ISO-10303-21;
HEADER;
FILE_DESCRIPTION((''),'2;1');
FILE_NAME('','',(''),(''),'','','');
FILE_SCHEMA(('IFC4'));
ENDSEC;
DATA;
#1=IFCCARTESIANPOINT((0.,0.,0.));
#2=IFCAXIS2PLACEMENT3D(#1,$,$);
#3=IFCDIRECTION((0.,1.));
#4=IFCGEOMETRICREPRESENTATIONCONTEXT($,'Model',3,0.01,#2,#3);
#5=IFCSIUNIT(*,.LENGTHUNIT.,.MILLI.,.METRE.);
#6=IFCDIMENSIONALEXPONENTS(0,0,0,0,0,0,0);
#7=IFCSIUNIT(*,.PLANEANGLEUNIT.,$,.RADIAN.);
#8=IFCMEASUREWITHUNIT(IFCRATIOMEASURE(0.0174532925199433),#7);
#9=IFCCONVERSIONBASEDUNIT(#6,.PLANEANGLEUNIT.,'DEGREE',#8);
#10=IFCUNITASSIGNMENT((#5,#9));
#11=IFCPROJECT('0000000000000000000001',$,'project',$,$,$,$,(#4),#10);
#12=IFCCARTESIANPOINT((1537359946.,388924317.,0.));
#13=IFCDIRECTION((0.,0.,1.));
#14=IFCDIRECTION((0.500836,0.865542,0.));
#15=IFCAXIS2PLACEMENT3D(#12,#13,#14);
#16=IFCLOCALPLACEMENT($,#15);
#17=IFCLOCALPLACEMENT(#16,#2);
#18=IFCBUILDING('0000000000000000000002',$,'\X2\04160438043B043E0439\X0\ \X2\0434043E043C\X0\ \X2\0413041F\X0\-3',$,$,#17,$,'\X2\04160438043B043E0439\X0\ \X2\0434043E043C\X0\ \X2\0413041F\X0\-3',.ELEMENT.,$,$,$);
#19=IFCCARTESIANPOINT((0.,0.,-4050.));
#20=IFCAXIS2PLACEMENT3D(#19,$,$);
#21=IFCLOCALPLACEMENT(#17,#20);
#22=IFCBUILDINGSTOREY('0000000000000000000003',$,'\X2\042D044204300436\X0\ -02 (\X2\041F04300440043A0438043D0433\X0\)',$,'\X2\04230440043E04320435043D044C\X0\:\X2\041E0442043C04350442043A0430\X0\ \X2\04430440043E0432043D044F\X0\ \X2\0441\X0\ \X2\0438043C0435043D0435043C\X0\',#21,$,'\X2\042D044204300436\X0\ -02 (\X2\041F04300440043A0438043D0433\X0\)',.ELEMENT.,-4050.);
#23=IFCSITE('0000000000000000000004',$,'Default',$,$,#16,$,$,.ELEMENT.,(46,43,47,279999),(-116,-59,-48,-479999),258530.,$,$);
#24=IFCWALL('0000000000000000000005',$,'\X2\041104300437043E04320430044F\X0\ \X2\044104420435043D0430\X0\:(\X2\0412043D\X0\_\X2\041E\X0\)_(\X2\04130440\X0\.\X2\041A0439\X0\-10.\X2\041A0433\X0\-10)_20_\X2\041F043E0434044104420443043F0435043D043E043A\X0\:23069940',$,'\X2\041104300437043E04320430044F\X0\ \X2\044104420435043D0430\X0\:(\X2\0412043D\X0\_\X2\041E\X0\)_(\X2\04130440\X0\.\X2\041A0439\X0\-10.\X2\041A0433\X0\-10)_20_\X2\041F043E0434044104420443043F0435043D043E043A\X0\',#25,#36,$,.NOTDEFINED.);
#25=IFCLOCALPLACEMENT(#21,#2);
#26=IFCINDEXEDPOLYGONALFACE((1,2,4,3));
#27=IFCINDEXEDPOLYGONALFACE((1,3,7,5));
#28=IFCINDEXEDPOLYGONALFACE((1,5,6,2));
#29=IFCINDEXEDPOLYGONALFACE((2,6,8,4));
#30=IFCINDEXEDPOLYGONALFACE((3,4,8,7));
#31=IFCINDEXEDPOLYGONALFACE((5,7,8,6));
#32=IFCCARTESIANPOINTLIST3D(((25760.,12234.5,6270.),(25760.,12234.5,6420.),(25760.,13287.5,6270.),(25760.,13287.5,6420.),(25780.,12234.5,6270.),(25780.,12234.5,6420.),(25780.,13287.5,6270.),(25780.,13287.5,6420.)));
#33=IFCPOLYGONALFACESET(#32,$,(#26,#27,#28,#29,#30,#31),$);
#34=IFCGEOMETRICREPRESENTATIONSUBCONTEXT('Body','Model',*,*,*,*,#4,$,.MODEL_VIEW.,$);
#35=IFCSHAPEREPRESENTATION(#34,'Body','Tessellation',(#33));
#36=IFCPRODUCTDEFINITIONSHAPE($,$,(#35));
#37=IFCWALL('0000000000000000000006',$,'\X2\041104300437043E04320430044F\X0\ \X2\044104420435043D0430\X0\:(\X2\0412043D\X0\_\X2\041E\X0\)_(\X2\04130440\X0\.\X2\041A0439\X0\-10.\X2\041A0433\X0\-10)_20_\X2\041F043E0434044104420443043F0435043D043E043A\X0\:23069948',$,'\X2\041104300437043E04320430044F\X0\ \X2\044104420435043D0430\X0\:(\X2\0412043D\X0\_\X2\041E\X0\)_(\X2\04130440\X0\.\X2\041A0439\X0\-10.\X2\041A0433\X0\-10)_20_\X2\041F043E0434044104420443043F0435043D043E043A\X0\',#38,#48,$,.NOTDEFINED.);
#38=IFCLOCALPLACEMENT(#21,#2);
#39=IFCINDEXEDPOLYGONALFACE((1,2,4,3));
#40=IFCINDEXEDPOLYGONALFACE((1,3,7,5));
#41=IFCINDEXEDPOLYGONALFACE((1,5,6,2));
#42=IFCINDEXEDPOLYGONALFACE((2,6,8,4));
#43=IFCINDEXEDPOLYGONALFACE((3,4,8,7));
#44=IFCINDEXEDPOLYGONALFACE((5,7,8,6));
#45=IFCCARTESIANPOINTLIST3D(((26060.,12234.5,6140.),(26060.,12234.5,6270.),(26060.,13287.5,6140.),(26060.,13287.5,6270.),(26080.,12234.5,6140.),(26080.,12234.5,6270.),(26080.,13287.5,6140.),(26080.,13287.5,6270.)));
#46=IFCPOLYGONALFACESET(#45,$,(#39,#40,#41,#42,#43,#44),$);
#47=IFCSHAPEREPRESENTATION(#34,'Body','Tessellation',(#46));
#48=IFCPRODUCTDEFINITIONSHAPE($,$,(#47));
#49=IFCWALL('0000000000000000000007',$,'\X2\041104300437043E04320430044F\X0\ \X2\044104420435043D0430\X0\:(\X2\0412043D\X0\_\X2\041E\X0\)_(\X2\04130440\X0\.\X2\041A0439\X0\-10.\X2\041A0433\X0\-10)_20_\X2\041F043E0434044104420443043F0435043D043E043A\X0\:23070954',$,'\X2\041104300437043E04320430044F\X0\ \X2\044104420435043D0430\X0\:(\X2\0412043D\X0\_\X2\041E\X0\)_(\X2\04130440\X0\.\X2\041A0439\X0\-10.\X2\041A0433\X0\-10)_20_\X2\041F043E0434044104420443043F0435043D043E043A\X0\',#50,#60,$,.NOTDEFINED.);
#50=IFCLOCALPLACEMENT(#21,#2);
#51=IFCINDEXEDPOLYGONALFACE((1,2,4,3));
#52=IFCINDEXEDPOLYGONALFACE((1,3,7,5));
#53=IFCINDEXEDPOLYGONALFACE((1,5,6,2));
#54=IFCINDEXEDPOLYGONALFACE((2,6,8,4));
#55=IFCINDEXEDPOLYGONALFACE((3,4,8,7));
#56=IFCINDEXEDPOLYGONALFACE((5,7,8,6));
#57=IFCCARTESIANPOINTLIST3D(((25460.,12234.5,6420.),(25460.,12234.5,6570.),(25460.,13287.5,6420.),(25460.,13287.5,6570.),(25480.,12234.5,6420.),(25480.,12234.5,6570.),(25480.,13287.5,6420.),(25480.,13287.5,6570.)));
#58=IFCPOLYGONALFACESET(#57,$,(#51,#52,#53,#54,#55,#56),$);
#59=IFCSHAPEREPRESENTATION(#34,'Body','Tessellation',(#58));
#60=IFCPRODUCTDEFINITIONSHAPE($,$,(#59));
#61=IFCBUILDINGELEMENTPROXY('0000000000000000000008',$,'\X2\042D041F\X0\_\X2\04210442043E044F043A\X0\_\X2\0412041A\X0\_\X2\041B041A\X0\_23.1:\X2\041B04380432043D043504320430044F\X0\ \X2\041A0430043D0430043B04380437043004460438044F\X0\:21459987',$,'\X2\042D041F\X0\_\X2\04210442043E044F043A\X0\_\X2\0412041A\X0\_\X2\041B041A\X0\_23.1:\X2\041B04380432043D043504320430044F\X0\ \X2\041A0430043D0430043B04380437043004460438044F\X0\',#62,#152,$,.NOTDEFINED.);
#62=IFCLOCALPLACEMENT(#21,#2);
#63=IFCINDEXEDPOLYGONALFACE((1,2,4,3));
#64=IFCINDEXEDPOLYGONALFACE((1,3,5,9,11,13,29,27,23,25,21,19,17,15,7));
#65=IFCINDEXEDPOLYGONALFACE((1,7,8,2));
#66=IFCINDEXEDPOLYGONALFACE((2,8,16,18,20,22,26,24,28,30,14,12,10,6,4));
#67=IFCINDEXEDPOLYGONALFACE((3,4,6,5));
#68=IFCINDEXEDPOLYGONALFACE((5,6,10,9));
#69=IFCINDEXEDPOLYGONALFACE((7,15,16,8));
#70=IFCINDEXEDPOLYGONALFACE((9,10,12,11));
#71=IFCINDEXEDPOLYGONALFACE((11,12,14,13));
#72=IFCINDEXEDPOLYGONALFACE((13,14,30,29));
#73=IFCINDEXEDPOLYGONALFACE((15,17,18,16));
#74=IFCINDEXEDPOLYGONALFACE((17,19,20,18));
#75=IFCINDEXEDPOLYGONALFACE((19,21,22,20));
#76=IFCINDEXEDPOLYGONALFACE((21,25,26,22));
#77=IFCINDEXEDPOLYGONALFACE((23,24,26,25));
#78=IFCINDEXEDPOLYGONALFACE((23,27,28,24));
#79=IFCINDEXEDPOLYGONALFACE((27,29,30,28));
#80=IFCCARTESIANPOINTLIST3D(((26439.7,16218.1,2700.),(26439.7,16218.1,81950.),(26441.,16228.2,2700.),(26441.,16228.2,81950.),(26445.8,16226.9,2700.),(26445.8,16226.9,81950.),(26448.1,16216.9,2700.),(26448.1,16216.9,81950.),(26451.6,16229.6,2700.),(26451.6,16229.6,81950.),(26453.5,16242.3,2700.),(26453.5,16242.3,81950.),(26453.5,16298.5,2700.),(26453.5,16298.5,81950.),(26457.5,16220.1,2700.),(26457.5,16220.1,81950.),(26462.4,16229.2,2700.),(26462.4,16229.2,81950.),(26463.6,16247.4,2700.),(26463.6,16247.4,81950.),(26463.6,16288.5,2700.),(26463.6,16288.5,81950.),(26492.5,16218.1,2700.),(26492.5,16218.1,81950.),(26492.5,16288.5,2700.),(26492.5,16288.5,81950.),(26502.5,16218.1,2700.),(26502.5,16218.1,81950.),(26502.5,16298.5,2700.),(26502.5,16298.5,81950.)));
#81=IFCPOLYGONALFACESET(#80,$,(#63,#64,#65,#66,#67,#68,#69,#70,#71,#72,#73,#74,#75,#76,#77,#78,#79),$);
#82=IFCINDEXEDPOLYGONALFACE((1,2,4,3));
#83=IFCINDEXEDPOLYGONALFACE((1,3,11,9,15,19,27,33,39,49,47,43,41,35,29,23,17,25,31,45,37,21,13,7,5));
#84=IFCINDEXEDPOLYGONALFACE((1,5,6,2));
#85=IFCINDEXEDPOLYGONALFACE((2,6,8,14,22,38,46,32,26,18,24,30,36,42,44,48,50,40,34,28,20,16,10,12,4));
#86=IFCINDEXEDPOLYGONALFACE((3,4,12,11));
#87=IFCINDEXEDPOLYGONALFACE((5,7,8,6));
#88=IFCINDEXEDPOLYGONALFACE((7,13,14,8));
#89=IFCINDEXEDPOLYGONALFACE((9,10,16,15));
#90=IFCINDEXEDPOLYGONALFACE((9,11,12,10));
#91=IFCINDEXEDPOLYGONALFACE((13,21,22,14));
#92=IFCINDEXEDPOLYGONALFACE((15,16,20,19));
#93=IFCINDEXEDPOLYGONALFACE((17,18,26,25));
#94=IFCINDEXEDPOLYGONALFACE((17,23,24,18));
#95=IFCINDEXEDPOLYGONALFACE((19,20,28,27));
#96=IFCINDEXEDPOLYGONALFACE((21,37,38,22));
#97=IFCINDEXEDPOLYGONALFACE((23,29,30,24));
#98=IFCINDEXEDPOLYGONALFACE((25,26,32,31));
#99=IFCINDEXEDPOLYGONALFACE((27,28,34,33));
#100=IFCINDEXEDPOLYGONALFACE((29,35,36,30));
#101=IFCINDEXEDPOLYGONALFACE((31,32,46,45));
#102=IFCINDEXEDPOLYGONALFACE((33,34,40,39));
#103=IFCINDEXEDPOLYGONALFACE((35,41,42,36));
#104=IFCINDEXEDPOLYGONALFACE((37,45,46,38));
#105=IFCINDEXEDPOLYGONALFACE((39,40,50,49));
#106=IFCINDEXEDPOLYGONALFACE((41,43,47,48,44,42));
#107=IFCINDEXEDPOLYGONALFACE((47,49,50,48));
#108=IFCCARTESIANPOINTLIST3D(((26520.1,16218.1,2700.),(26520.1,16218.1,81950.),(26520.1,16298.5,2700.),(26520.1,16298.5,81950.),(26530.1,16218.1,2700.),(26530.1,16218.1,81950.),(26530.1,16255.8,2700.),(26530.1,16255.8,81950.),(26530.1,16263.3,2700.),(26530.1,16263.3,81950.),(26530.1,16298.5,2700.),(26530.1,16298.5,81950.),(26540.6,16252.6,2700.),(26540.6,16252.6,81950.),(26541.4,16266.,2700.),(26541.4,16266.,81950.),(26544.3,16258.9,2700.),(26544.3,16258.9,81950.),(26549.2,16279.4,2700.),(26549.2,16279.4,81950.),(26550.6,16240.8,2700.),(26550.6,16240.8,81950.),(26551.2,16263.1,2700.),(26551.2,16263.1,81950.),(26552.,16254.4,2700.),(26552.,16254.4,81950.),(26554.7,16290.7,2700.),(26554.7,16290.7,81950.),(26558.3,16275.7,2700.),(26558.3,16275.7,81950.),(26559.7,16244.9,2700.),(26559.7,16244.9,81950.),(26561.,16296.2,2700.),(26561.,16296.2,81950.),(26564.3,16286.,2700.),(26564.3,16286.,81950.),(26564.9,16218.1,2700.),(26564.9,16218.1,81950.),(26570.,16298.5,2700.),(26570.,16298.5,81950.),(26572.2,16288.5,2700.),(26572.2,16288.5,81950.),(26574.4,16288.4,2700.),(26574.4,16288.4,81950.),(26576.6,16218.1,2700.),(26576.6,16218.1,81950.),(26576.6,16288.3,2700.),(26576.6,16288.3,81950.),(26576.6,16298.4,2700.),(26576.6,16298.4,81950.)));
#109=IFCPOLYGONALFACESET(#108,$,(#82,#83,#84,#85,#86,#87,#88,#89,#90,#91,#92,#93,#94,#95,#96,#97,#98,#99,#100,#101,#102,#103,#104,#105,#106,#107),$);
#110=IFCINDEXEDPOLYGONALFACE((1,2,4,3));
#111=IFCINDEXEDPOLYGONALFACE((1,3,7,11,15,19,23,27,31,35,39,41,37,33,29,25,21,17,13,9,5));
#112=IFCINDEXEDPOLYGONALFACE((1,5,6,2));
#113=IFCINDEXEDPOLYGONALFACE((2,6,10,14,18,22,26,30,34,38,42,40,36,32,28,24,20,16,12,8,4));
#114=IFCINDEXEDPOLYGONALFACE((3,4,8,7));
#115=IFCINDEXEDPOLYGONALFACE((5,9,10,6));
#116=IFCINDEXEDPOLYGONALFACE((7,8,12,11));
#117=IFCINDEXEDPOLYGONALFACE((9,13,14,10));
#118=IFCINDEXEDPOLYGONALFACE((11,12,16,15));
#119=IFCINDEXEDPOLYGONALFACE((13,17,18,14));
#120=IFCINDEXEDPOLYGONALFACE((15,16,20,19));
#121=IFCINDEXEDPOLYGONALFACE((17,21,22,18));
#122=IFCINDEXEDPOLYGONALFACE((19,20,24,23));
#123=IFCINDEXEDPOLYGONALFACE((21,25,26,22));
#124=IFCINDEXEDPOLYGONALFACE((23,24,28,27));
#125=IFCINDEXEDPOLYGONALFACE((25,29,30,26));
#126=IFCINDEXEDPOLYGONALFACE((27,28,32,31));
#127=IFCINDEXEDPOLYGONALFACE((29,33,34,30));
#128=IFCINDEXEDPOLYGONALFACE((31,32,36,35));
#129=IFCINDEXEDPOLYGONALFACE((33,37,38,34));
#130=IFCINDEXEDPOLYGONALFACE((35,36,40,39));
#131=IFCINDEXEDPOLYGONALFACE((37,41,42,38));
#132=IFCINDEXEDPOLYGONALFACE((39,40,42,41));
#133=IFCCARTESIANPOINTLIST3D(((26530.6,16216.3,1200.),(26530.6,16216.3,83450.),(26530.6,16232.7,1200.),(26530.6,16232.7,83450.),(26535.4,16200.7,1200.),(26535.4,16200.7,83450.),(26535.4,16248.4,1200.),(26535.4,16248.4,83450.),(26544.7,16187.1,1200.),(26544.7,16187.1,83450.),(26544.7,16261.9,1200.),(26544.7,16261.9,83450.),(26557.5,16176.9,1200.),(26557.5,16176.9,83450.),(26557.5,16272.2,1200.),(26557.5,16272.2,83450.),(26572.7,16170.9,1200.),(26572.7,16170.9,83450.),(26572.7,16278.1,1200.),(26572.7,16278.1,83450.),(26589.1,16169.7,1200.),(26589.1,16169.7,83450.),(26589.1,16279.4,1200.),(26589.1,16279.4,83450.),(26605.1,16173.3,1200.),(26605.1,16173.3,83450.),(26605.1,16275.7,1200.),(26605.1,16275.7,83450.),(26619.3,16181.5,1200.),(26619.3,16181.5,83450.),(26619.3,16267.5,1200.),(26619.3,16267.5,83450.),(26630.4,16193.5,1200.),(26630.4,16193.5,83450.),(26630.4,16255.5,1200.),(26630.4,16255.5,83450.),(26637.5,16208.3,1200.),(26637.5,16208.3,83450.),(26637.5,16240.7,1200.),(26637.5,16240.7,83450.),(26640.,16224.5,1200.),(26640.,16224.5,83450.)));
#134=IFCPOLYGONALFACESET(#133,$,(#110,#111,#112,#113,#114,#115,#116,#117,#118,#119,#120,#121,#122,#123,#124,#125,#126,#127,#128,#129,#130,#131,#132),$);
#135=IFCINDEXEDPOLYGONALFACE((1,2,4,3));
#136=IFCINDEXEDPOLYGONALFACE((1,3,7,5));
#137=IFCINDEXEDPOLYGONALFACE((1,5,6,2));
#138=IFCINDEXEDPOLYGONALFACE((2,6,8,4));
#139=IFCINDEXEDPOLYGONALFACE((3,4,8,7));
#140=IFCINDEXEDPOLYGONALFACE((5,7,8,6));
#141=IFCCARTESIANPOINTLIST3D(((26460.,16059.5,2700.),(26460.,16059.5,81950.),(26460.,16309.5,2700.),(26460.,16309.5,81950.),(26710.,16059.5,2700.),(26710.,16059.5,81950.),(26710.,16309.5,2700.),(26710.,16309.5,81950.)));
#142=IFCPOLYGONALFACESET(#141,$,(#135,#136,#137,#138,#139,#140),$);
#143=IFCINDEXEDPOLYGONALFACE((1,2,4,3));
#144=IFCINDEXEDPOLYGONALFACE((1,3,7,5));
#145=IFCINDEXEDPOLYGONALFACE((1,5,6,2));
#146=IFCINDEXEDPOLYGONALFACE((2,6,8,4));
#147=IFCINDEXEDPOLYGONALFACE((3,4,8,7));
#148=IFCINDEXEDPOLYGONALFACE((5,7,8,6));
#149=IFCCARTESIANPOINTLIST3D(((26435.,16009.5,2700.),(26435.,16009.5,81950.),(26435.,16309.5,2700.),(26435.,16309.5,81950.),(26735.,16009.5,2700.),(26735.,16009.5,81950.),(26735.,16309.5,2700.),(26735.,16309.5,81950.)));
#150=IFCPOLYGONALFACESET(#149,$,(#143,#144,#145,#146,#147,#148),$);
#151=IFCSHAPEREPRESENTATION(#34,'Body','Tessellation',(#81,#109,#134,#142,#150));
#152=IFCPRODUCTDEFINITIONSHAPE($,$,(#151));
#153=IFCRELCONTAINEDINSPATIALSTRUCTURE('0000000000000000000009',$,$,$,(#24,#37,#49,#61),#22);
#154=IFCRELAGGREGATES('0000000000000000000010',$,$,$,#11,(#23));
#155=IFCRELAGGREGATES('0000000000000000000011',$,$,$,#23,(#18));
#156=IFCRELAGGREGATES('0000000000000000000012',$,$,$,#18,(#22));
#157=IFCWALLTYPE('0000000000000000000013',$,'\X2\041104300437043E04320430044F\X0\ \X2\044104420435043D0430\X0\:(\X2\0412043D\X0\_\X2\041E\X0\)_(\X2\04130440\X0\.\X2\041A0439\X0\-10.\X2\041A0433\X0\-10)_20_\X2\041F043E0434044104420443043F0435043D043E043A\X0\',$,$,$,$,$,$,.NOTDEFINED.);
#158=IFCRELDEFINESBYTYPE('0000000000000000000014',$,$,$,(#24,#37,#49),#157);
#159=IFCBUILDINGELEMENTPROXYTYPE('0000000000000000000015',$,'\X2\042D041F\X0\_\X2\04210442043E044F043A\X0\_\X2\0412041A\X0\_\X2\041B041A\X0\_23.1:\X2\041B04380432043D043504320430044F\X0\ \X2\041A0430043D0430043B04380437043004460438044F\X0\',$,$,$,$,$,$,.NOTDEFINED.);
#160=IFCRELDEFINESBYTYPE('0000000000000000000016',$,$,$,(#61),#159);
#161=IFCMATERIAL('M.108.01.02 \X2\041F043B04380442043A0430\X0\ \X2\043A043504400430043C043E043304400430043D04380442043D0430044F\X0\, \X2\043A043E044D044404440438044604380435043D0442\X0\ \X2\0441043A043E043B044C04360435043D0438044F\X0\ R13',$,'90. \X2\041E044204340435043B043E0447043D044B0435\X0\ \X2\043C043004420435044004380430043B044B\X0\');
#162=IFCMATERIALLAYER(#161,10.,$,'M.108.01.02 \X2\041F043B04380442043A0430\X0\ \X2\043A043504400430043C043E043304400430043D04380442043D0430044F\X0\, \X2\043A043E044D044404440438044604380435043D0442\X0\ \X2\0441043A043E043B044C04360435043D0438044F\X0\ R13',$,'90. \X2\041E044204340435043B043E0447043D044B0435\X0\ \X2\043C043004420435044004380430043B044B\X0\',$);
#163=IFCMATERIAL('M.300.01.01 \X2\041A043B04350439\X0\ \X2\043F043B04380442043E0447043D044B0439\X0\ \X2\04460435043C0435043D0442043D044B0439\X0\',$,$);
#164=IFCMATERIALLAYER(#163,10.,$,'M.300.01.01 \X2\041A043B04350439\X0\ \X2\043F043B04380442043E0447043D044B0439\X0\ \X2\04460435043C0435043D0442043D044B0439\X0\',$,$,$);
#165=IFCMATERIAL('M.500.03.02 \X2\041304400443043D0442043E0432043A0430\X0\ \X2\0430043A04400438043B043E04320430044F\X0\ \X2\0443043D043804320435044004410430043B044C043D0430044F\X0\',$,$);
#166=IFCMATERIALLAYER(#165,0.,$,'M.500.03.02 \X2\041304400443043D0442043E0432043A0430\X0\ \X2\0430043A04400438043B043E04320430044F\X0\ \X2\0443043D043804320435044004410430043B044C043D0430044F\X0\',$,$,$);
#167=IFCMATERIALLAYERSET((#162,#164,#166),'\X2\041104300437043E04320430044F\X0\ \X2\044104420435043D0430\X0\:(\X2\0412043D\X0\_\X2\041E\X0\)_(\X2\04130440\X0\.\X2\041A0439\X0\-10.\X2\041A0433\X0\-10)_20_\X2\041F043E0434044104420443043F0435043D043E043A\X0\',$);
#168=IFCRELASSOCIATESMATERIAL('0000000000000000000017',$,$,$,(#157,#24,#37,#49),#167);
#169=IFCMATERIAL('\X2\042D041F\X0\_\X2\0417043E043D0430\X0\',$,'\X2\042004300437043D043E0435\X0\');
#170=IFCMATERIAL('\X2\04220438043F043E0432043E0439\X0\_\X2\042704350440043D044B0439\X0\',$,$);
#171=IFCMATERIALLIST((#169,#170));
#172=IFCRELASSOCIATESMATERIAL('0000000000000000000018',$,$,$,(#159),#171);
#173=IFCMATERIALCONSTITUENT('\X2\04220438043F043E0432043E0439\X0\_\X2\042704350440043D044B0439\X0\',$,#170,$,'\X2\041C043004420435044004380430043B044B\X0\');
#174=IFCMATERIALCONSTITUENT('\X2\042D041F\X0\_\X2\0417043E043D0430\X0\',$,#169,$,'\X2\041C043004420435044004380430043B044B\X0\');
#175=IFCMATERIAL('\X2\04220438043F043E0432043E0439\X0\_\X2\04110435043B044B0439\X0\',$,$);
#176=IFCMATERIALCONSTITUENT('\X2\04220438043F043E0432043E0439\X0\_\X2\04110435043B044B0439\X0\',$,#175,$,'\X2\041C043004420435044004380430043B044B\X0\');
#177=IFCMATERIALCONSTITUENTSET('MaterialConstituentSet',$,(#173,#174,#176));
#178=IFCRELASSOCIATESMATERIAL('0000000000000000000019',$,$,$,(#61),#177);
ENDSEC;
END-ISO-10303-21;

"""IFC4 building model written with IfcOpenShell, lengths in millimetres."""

from ifc_helpers import new_model, entity, si_unit, converted_unit, direction, frame, frame_2d, origin, place, context, subcontext, project, spatial, polyline, rectangle, circle, outline, extrude, source, transform, mapped, material, material_list, layer, layer_set, layer_usage, constituent, constituent_set, type_object, type_shapes, element, save


model = new_model("IFC4")

# Units and contexts
model_context = context("Model", 3, precision=0.01, world=origin(), true_north=direction((0.0, 1.0)))
body_context = subcontext(model_context, "Body", "Model", "MODEL_VIEW")
ifc_project = project(units=[si_unit("LENGTHUNIT", "METRE", prefix="MILLI"), converted_unit("PLANEANGLEUNIT", "DEGREE", entity("IfcRatioMeasure", 0.0174532925199433), si_unit("PLANEANGLEUNIT", "RADIAN"), dimensions=[0, 0, 0, 0, 0, 0, 0])], contexts=[model_context])

# Site, building, storey
site_placement = place(None, frame((1537359946.0, 388924317.0, 0.0), z_axis=(0.0, 0.0, 1.0), x_axis=(0.500836, 0.865542, 0.0)))
site = spatial("IfcSite", under=ifc_project, at=site_placement, Name="Default", CompositionType="ELEMENT", RefLatitude=(46, 43, 47, 279999), RefLongitude=(-116, -59, -48, -479999), RefElevation=258530.0)
building_placement = place(site_placement, origin())
building = spatial("IfcBuilding", under=site, at=building_placement, Name="Жилой дом ГП-3", LongName="Жилой дом ГП-3", CompositionType="ELEMENT")
storey_placement = place(building_placement, frame((0.0, 0.0, -4050.0)))
storey = spatial("IfcBuildingStorey", under=building, at=storey_placement, Name="Этаж -02 (Паркинг)", ObjectType="Уровень:Отметка уровня с именем", LongName="Этаж -02 (Паркинг)", CompositionType="ELEMENT", Elevation=-4050.0)

# Walls
ifc_material_1 = material(Name="M.108.01.02 Плитка керамогранитная, коэффициент скольжения R13", Category="90. Отделочные материалы")
ifc_layer_1 = layer(ifc_material_1, 10.0, Name="M.108.01.02 Плитка керамогранитная, коэффициент скольжения R13", Category="90. Отделочные материалы")
ifc_material_2 = material(Name="M.300.01.01 Клей плиточный цементный")
ifc_layer_2 = layer(ifc_material_2, 10.0, Name="M.300.01.01 Клей плиточный цементный")
ifc_material_3 = material(Name="M.500.03.02 Грунтовка акриловая универсальная")
ifc_layer_3 = layer(ifc_material_3, 0.0, Name="M.500.03.02 Грунтовка акриловая универсальная")
ifc_layer_set = layer_set([ifc_layer_1, ifc_layer_2, ifc_layer_3], Name="Базовая стена:(Вн_О)_(Гр.Кй-10.Кг-10)_20_Подступенок")
ifc_layer_usage_1 = layer_usage(ifc_layer_set, "AXIS2", "NEGATIVE", 10.0)
wall_type = type_object("IfcWallType", Name="Базовая стена:(Вн_О)_(Гр.Кй-10.Кг-10)_20_Подступенок", PredefinedType="NOTDEFINED", material=ifc_layer_set)
wall_1_placement = place(storey_placement, frame((25770.0, 13287.5, 6270.0), z_axis=(0.0, 0.0, 1.0), x_axis=(0.0, -1.0, 0.0)))
element("IfcWall", 1, at=wall_1_placement, inside=storey, type_object=wall_type, material=ifc_layer_usage_1, Name="Базовая стена:(Вн_О)_(Гр.Кй-10.Кг-10)_20_Подступенок:23069940", ObjectType="Базовая стена:(Вн_О)_(Гр.Кй-10.Кг-10)_20_Подступенок", PredefinedType="NOTDEFINED", context=body_context, shape_type="SweptSolid", body=[
    extrude(rectangle(XDim=1053.0, YDim=20.0, at=frame_2d((526.5, 0.0), x_axis=(-1.0, 0.0))), origin(), (0.0, 0.0, 1.0), 150.0),
])
ifc_layer_usage_2 = layer_usage(ifc_layer_set, "AXIS2", "NEGATIVE", 10.0)
wall_2_placement = place(storey_placement, frame((26070.0, 13287.5, 6140.0), z_axis=(0.0, 0.0, 1.0), x_axis=(0.0, -1.0, 0.0)))
element("IfcWall", 2, at=wall_2_placement, inside=storey, type_object=wall_type, material=ifc_layer_usage_2, Name="Базовая стена:(Вн_О)_(Гр.Кй-10.Кг-10)_20_Подступенок:23069948", ObjectType="Базовая стена:(Вн_О)_(Гр.Кй-10.Кг-10)_20_Подступенок", PredefinedType="NOTDEFINED", context=body_context, shape_type="SweptSolid", body=[
    extrude(rectangle(XDim=1053.0, YDim=20.0, at=frame_2d((526.5, 0.0), x_axis=(-1.0, 0.0))), origin(), (0.0, 0.0, 1.0), 130.0),
])
ifc_layer_usage_3 = layer_usage(ifc_layer_set, "AXIS2", "NEGATIVE", 10.0)
wall_3_placement = place(storey_placement, frame((25470.0, 13287.5, 6420.0), z_axis=(0.0, 0.0, 1.0), x_axis=(0.0, -1.0, 0.0)))
element("IfcWall", 3, at=wall_3_placement, inside=storey, type_object=wall_type, material=ifc_layer_usage_3, Name="Базовая стена:(Вн_О)_(Гр.Кй-10.Кг-10)_20_Подступенок:23070954", ObjectType="Базовая стена:(Вн_О)_(Гр.Кй-10.Кг-10)_20_Подступенок", PredefinedType="NOTDEFINED", context=body_context, shape_type="SweptSolid", body=[
    extrude(rectangle(XDim=1053.0, YDim=20.0, at=frame_2d((526.5, 0.0), x_axis=(-1.0, 0.0))), origin(), (0.0, 0.0, 1.0), 150.0),
])

# Building element proxy
ifc_material_4 = material(Name="Типовой_Черный")
ifc_constituent_1 = constituent(ifc_material_4, Name="Типовой_Черный", Category="Материалы")
ifc_material_5 = material(Name="ЭП_Зона", Category="Разное")
ifc_constituent_2 = constituent(ifc_material_5, Name="ЭП_Зона", Category="Материалы")
ifc_material_6 = material(Name="Типовой_Белый")
ifc_constituent_3 = constituent(ifc_material_6, Name="Типовой_Белый", Category="Материалы")
ifc_constituent_set_1 = constituent_set(constituents=[ifc_constituent_1, ifc_constituent_2, ifc_constituent_3], Name="MaterialConstituentSet")
ifc_material_list_1 = material_list([ifc_material_5, ifc_material_4])
building_element_proxy_type_1 = type_object("IfcBuildingElementProxyType", Name="ЭП_Стояк_ВК_ЛК_23.1:Ливневая Канализация", PredefinedType="NOTDEFINED", material=ifc_material_list_1)
shared_shape_1 = source(origin(), body_context, "Body", "SweptSolid", [
    extrude(outline(polyline([(-53.9, 11.1), (-53.9, -37.8), (26.5, -37.8), (26.5, -27.8), (-43.9, -27.8), (-43.9, 1.1), (-2.9, 1.1), (15.4, 2.3), (24.5, 7.2), (27.7, 16.6), (26.5, 25.0), (16.4, 23.7), (17.7, 18.9), (15.0, 13.1), (2.3, 11.1), (-53.9, 11.1)])), frame((29.7, -64.9, -1350.0), z_axis=(0.0, 0.0, -1.0), x_axis=(0.0, -1.0, 0.0)), (0.0, 0.0, -1.0), 79250.0),
    extrude(outline(polyline([(-32.1, -31.9), (48.3, -31.9), (48.3, -21.8), (10.6, -21.8), (13.8, -11.4), (25.6, -1.3), (48.3, 13.0), (48.3, 24.6), (21.4, 7.7), (12.0, 0.1), (7.4, -7.7), (3.3, -0.7), (-9.3, 6.4), (-19.7, 12.3), (-22.1, 20.2), (-22.0, 22.4), (-22.0, 24.6), (-32.0, 24.6), (-32.1, 18.0), (-29.9, 9.0), (-24.3, 2.8), (-13.1, -2.8), (0.4, -10.6), (3.0, -21.8), (-32.1, -21.8), (-32.1, -31.9)])), frame((117.0, -43.1, -1350.0), z_axis=(0.0, 0.0, 1.0), x_axis=(0.0, -1.0, 0.0)), (0.0, 0.0, 1.0), 79250.0),
    extrude(circle(Radius=55.0, at=frame_2d((0.0, 0.0), x_axis=(1.0, 0.0))), frame((150.0, -85.0, -2850.0)), (0.0, 0.0, 1.0), 82250.0),
    extrude(rectangle(XDim=250.0, YDim=250.0, at=frame_2d((0.0, 0.0), x_axis=(1.0, 0.0))), frame((150.0, -125.0, -1350.0)), (0.0, 0.0, 1.0), 79250.0),
    extrude(rectangle(XDim=300.0, YDim=300.0, at=frame_2d((0.0, 0.0), x_axis=(1.0, 0.0))), frame((150.0, -150.0, -1350.0)), (0.0, 0.0, 1.0), 79250.0),
])
type_shapes(building_element_proxy_type_1, [shared_shape_1])
proxy_1_placement = place(storey_placement, frame((26435.0, 16309.5, 4050.0)))
element("IfcBuildingElementProxy", 4, at=proxy_1_placement, inside=storey, type_object=building_element_proxy_type_1, material=ifc_constituent_set_1, Name="ЭП_Стояк_ВК_ЛК_23.1:Ливневая Канализация:21459987", ObjectType="ЭП_Стояк_ВК_ЛК_23.1:Ливневая Канализация", PredefinedType="NOTDEFINED", context=body_context, shape_type="MappedRepresentation", body=[
    mapped(shared_shape_1, transform((0.0, 0.0, 0.0), scale=1.0)),
])

save(model, "model.ifc")
